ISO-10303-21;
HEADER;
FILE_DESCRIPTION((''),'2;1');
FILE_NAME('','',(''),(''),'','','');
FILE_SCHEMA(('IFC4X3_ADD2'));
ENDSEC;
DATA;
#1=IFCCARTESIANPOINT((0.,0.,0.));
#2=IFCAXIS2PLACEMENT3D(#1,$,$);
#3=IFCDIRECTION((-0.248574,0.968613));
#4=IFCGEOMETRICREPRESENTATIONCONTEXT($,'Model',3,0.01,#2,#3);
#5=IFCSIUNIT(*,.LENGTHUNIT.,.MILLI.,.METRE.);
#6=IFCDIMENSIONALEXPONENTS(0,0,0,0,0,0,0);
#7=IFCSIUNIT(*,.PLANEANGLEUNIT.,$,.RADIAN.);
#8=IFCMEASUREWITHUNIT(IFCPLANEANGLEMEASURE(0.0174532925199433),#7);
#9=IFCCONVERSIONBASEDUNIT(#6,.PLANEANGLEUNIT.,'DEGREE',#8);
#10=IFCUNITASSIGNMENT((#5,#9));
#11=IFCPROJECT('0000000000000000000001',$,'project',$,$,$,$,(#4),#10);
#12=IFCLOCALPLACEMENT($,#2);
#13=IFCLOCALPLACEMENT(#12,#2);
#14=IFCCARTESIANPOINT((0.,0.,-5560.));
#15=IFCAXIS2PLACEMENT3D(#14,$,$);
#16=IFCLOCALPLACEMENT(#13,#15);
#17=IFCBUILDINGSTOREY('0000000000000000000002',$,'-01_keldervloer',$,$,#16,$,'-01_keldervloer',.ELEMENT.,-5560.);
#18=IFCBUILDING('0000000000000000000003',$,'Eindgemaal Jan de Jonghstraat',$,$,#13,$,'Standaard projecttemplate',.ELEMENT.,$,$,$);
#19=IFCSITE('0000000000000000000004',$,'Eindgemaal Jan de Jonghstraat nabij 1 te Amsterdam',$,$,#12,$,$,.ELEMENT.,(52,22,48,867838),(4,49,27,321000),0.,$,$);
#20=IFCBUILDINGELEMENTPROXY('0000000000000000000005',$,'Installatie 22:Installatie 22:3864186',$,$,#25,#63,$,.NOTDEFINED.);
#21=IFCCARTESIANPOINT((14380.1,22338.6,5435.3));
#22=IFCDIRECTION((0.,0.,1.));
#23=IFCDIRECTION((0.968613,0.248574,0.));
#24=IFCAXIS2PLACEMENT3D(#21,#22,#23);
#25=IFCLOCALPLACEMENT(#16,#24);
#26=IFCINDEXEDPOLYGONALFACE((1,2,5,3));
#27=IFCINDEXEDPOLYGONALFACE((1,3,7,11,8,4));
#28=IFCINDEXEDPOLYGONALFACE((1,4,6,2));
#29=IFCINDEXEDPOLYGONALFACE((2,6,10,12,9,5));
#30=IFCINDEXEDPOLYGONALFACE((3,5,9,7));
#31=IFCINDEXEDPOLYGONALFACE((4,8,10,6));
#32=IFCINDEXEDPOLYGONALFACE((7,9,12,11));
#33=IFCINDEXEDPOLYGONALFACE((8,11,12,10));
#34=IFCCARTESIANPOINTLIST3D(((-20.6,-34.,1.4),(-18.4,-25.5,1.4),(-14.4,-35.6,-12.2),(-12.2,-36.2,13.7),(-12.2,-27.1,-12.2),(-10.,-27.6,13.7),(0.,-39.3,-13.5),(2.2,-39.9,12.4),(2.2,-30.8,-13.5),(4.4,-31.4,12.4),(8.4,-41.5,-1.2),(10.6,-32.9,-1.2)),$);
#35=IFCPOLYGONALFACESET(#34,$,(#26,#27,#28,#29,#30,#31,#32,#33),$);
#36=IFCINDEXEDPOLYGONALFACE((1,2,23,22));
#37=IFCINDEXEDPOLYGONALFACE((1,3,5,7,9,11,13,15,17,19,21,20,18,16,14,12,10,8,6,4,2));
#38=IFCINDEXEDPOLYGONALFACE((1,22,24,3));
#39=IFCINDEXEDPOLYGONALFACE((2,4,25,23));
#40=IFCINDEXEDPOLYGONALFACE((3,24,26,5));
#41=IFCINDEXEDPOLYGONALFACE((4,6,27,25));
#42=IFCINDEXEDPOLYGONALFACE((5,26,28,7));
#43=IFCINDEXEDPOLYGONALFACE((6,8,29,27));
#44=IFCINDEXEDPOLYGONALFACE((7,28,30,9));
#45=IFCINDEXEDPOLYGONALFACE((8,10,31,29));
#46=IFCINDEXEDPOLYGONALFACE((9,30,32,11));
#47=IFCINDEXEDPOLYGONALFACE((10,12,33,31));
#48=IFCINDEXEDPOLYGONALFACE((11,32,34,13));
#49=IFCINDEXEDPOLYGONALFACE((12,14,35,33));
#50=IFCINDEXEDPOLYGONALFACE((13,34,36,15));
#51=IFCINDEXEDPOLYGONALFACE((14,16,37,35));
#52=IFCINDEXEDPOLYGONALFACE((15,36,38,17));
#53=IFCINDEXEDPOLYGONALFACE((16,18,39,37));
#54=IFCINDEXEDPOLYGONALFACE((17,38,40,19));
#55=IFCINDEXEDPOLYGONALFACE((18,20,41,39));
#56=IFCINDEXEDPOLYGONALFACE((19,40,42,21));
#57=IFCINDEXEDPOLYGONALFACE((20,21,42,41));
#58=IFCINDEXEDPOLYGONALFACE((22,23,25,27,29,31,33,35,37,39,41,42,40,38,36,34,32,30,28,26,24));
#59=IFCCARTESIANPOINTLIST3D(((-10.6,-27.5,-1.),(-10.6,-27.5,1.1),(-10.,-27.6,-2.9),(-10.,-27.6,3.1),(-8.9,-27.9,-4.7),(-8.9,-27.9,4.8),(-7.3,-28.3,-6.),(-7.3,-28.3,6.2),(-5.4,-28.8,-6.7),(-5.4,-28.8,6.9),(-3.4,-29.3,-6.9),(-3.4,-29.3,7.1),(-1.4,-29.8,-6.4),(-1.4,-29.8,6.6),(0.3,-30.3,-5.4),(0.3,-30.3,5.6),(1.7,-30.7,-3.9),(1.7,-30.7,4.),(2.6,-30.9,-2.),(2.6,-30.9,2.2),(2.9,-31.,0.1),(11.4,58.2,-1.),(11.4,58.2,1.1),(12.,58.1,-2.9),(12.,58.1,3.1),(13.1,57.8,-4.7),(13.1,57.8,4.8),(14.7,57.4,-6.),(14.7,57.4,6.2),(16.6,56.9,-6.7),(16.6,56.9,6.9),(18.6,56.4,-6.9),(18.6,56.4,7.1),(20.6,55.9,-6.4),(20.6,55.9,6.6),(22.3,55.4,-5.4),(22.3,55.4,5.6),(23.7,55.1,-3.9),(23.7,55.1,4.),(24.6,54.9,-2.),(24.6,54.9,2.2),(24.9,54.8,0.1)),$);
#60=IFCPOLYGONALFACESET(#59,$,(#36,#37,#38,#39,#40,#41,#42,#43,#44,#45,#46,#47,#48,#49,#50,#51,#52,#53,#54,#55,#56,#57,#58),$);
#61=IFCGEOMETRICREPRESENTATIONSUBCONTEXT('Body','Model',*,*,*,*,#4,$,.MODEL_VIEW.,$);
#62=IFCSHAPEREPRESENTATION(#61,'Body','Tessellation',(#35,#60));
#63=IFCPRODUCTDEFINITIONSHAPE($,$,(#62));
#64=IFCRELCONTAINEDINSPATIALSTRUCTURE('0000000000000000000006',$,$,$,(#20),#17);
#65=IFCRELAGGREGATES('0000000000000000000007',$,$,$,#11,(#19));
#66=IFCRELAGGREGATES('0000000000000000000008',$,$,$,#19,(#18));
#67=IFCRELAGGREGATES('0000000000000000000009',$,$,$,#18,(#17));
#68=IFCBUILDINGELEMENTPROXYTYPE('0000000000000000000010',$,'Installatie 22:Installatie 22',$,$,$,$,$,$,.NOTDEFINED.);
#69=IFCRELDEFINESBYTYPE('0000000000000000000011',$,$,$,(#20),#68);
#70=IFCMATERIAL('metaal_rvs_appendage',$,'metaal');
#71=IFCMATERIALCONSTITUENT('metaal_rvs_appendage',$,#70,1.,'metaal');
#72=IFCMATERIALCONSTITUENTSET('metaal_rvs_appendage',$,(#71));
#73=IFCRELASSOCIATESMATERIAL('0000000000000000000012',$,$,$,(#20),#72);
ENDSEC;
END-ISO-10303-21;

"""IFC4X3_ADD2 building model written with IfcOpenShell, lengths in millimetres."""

from ifc_helpers import new_model, entity, si_unit, converted_unit, direction, frame, frame_2d, origin, place, context, subcontext, project, spatial, polyline, circle, outline, extrude, source, transform, mapped, material, constituent, constituent_set, type_object, type_shapes, element, save


model = new_model("IFC4X3_ADD2")

# Units and contexts
model_context = context("Model", 3, precision=0.01, world=origin(), true_north=direction((-0.248574, 0.968613)))
body_context = subcontext(model_context, "Body", "Model", "MODEL_VIEW")
ifc_project = project(units=[si_unit("LENGTHUNIT", "METRE", prefix="MILLI"), converted_unit("PLANEANGLEUNIT", "DEGREE", entity("IfcPlaneAngleMeasure", 0.0174532925199433), si_unit("PLANEANGLEUNIT", "RADIAN"), dimensions=[0, 0, 0, 0, 0, 0, 0])], contexts=[model_context])

# Site, building, storey
site_placement = place(None, origin())
site = spatial("IfcSite", under=ifc_project, at=site_placement, Name="Eindgemaal Jan de Jonghstraat nabij 1 te Amsterdam", CompositionType="ELEMENT", RefLatitude=(52, 22, 48, 867838), RefLongitude=(4, 49, 27, 321000), RefElevation=0.0)
building_placement = place(site_placement, origin())
building = spatial("IfcBuilding", under=site, at=building_placement, Name="Eindgemaal Jan de Jonghstraat", LongName="Standaard projecttemplate", CompositionType="ELEMENT")
storey_placement = place(building_placement, frame((0.0, 0.0, -5560.0)))
storey = spatial("IfcBuildingStorey", under=building, at=storey_placement, Name="-01_keldervloer", LongName="-01_keldervloer", CompositionType="ELEMENT", Elevation=-5560.0)

# Building element proxy
ifc_material_1 = material(Name="metaal_rvs_appendage", Category="metaal")
ifc_constituent_1 = constituent(ifc_material_1, Name="metaal_rvs_appendage", Category="metaal", fraction=1.0)
ifc_constituent_set_1 = constituent_set(constituents=[ifc_constituent_1], Name="metaal_rvs_appendage")
building_element_proxy_type_1 = type_object("IfcBuildingElementProxyType", Name="Installatie 22:Installatie 22", PredefinedType="NOTDEFINED")
shared_shape_1 = source(origin(), body_context, "Body", "SweptSolid", [
    extrude(outline(polyline([(-7.5, -13.0), (7.5, -13.0), (15.0, 0.0), (7.5, 13.0), (-7.5, 13.0), (-15.0, 0.0), (-7.5, -13.0)])), frame((-6.1, -37.8, 0.1), z_axis=(0.248574, 0.968613, 0.0), x_axis=(-0.555573, 0.142576, -0.819152)), (0.0, 0.0, 1.0), 8.8),
    extrude(circle(Radius=7.0, at=frame_2d((0.0, 0.0), x_axis=(1.0, 0.0))), frame((-3.9, -29.2, 0.1), z_axis=(0.248574, 0.968613, 0.0), x_axis=(0.968613, -0.248574, 0.0)), (0.0, 0.0, 1.0), 88.5),
])
type_shapes(building_element_proxy_type_1, [shared_shape_1])
for number, where, z_axis, x_axis, name in (
    (1, (14380.1, 22338.6, 5435.3), (0.0, 0.0, 1.0), (0.968613, 0.248574, 0.0), "Installatie 22:Installatie 22:3864186"),
):
    element("IfcBuildingElementProxy", number, at=place(storey_placement, frame(where, z_axis=z_axis, x_axis=x_axis)), inside=storey, type_object=building_element_proxy_type_1, material=ifc_constituent_set_1, Name=name, PredefinedType="NOTDEFINED", context=body_context, shape_type="MappedRepresentation", body=[
        mapped(shared_shape_1, transform((0.0, 0.0, 0.0), scale=1.0)),
    ])

save(model, "model.ifc")
